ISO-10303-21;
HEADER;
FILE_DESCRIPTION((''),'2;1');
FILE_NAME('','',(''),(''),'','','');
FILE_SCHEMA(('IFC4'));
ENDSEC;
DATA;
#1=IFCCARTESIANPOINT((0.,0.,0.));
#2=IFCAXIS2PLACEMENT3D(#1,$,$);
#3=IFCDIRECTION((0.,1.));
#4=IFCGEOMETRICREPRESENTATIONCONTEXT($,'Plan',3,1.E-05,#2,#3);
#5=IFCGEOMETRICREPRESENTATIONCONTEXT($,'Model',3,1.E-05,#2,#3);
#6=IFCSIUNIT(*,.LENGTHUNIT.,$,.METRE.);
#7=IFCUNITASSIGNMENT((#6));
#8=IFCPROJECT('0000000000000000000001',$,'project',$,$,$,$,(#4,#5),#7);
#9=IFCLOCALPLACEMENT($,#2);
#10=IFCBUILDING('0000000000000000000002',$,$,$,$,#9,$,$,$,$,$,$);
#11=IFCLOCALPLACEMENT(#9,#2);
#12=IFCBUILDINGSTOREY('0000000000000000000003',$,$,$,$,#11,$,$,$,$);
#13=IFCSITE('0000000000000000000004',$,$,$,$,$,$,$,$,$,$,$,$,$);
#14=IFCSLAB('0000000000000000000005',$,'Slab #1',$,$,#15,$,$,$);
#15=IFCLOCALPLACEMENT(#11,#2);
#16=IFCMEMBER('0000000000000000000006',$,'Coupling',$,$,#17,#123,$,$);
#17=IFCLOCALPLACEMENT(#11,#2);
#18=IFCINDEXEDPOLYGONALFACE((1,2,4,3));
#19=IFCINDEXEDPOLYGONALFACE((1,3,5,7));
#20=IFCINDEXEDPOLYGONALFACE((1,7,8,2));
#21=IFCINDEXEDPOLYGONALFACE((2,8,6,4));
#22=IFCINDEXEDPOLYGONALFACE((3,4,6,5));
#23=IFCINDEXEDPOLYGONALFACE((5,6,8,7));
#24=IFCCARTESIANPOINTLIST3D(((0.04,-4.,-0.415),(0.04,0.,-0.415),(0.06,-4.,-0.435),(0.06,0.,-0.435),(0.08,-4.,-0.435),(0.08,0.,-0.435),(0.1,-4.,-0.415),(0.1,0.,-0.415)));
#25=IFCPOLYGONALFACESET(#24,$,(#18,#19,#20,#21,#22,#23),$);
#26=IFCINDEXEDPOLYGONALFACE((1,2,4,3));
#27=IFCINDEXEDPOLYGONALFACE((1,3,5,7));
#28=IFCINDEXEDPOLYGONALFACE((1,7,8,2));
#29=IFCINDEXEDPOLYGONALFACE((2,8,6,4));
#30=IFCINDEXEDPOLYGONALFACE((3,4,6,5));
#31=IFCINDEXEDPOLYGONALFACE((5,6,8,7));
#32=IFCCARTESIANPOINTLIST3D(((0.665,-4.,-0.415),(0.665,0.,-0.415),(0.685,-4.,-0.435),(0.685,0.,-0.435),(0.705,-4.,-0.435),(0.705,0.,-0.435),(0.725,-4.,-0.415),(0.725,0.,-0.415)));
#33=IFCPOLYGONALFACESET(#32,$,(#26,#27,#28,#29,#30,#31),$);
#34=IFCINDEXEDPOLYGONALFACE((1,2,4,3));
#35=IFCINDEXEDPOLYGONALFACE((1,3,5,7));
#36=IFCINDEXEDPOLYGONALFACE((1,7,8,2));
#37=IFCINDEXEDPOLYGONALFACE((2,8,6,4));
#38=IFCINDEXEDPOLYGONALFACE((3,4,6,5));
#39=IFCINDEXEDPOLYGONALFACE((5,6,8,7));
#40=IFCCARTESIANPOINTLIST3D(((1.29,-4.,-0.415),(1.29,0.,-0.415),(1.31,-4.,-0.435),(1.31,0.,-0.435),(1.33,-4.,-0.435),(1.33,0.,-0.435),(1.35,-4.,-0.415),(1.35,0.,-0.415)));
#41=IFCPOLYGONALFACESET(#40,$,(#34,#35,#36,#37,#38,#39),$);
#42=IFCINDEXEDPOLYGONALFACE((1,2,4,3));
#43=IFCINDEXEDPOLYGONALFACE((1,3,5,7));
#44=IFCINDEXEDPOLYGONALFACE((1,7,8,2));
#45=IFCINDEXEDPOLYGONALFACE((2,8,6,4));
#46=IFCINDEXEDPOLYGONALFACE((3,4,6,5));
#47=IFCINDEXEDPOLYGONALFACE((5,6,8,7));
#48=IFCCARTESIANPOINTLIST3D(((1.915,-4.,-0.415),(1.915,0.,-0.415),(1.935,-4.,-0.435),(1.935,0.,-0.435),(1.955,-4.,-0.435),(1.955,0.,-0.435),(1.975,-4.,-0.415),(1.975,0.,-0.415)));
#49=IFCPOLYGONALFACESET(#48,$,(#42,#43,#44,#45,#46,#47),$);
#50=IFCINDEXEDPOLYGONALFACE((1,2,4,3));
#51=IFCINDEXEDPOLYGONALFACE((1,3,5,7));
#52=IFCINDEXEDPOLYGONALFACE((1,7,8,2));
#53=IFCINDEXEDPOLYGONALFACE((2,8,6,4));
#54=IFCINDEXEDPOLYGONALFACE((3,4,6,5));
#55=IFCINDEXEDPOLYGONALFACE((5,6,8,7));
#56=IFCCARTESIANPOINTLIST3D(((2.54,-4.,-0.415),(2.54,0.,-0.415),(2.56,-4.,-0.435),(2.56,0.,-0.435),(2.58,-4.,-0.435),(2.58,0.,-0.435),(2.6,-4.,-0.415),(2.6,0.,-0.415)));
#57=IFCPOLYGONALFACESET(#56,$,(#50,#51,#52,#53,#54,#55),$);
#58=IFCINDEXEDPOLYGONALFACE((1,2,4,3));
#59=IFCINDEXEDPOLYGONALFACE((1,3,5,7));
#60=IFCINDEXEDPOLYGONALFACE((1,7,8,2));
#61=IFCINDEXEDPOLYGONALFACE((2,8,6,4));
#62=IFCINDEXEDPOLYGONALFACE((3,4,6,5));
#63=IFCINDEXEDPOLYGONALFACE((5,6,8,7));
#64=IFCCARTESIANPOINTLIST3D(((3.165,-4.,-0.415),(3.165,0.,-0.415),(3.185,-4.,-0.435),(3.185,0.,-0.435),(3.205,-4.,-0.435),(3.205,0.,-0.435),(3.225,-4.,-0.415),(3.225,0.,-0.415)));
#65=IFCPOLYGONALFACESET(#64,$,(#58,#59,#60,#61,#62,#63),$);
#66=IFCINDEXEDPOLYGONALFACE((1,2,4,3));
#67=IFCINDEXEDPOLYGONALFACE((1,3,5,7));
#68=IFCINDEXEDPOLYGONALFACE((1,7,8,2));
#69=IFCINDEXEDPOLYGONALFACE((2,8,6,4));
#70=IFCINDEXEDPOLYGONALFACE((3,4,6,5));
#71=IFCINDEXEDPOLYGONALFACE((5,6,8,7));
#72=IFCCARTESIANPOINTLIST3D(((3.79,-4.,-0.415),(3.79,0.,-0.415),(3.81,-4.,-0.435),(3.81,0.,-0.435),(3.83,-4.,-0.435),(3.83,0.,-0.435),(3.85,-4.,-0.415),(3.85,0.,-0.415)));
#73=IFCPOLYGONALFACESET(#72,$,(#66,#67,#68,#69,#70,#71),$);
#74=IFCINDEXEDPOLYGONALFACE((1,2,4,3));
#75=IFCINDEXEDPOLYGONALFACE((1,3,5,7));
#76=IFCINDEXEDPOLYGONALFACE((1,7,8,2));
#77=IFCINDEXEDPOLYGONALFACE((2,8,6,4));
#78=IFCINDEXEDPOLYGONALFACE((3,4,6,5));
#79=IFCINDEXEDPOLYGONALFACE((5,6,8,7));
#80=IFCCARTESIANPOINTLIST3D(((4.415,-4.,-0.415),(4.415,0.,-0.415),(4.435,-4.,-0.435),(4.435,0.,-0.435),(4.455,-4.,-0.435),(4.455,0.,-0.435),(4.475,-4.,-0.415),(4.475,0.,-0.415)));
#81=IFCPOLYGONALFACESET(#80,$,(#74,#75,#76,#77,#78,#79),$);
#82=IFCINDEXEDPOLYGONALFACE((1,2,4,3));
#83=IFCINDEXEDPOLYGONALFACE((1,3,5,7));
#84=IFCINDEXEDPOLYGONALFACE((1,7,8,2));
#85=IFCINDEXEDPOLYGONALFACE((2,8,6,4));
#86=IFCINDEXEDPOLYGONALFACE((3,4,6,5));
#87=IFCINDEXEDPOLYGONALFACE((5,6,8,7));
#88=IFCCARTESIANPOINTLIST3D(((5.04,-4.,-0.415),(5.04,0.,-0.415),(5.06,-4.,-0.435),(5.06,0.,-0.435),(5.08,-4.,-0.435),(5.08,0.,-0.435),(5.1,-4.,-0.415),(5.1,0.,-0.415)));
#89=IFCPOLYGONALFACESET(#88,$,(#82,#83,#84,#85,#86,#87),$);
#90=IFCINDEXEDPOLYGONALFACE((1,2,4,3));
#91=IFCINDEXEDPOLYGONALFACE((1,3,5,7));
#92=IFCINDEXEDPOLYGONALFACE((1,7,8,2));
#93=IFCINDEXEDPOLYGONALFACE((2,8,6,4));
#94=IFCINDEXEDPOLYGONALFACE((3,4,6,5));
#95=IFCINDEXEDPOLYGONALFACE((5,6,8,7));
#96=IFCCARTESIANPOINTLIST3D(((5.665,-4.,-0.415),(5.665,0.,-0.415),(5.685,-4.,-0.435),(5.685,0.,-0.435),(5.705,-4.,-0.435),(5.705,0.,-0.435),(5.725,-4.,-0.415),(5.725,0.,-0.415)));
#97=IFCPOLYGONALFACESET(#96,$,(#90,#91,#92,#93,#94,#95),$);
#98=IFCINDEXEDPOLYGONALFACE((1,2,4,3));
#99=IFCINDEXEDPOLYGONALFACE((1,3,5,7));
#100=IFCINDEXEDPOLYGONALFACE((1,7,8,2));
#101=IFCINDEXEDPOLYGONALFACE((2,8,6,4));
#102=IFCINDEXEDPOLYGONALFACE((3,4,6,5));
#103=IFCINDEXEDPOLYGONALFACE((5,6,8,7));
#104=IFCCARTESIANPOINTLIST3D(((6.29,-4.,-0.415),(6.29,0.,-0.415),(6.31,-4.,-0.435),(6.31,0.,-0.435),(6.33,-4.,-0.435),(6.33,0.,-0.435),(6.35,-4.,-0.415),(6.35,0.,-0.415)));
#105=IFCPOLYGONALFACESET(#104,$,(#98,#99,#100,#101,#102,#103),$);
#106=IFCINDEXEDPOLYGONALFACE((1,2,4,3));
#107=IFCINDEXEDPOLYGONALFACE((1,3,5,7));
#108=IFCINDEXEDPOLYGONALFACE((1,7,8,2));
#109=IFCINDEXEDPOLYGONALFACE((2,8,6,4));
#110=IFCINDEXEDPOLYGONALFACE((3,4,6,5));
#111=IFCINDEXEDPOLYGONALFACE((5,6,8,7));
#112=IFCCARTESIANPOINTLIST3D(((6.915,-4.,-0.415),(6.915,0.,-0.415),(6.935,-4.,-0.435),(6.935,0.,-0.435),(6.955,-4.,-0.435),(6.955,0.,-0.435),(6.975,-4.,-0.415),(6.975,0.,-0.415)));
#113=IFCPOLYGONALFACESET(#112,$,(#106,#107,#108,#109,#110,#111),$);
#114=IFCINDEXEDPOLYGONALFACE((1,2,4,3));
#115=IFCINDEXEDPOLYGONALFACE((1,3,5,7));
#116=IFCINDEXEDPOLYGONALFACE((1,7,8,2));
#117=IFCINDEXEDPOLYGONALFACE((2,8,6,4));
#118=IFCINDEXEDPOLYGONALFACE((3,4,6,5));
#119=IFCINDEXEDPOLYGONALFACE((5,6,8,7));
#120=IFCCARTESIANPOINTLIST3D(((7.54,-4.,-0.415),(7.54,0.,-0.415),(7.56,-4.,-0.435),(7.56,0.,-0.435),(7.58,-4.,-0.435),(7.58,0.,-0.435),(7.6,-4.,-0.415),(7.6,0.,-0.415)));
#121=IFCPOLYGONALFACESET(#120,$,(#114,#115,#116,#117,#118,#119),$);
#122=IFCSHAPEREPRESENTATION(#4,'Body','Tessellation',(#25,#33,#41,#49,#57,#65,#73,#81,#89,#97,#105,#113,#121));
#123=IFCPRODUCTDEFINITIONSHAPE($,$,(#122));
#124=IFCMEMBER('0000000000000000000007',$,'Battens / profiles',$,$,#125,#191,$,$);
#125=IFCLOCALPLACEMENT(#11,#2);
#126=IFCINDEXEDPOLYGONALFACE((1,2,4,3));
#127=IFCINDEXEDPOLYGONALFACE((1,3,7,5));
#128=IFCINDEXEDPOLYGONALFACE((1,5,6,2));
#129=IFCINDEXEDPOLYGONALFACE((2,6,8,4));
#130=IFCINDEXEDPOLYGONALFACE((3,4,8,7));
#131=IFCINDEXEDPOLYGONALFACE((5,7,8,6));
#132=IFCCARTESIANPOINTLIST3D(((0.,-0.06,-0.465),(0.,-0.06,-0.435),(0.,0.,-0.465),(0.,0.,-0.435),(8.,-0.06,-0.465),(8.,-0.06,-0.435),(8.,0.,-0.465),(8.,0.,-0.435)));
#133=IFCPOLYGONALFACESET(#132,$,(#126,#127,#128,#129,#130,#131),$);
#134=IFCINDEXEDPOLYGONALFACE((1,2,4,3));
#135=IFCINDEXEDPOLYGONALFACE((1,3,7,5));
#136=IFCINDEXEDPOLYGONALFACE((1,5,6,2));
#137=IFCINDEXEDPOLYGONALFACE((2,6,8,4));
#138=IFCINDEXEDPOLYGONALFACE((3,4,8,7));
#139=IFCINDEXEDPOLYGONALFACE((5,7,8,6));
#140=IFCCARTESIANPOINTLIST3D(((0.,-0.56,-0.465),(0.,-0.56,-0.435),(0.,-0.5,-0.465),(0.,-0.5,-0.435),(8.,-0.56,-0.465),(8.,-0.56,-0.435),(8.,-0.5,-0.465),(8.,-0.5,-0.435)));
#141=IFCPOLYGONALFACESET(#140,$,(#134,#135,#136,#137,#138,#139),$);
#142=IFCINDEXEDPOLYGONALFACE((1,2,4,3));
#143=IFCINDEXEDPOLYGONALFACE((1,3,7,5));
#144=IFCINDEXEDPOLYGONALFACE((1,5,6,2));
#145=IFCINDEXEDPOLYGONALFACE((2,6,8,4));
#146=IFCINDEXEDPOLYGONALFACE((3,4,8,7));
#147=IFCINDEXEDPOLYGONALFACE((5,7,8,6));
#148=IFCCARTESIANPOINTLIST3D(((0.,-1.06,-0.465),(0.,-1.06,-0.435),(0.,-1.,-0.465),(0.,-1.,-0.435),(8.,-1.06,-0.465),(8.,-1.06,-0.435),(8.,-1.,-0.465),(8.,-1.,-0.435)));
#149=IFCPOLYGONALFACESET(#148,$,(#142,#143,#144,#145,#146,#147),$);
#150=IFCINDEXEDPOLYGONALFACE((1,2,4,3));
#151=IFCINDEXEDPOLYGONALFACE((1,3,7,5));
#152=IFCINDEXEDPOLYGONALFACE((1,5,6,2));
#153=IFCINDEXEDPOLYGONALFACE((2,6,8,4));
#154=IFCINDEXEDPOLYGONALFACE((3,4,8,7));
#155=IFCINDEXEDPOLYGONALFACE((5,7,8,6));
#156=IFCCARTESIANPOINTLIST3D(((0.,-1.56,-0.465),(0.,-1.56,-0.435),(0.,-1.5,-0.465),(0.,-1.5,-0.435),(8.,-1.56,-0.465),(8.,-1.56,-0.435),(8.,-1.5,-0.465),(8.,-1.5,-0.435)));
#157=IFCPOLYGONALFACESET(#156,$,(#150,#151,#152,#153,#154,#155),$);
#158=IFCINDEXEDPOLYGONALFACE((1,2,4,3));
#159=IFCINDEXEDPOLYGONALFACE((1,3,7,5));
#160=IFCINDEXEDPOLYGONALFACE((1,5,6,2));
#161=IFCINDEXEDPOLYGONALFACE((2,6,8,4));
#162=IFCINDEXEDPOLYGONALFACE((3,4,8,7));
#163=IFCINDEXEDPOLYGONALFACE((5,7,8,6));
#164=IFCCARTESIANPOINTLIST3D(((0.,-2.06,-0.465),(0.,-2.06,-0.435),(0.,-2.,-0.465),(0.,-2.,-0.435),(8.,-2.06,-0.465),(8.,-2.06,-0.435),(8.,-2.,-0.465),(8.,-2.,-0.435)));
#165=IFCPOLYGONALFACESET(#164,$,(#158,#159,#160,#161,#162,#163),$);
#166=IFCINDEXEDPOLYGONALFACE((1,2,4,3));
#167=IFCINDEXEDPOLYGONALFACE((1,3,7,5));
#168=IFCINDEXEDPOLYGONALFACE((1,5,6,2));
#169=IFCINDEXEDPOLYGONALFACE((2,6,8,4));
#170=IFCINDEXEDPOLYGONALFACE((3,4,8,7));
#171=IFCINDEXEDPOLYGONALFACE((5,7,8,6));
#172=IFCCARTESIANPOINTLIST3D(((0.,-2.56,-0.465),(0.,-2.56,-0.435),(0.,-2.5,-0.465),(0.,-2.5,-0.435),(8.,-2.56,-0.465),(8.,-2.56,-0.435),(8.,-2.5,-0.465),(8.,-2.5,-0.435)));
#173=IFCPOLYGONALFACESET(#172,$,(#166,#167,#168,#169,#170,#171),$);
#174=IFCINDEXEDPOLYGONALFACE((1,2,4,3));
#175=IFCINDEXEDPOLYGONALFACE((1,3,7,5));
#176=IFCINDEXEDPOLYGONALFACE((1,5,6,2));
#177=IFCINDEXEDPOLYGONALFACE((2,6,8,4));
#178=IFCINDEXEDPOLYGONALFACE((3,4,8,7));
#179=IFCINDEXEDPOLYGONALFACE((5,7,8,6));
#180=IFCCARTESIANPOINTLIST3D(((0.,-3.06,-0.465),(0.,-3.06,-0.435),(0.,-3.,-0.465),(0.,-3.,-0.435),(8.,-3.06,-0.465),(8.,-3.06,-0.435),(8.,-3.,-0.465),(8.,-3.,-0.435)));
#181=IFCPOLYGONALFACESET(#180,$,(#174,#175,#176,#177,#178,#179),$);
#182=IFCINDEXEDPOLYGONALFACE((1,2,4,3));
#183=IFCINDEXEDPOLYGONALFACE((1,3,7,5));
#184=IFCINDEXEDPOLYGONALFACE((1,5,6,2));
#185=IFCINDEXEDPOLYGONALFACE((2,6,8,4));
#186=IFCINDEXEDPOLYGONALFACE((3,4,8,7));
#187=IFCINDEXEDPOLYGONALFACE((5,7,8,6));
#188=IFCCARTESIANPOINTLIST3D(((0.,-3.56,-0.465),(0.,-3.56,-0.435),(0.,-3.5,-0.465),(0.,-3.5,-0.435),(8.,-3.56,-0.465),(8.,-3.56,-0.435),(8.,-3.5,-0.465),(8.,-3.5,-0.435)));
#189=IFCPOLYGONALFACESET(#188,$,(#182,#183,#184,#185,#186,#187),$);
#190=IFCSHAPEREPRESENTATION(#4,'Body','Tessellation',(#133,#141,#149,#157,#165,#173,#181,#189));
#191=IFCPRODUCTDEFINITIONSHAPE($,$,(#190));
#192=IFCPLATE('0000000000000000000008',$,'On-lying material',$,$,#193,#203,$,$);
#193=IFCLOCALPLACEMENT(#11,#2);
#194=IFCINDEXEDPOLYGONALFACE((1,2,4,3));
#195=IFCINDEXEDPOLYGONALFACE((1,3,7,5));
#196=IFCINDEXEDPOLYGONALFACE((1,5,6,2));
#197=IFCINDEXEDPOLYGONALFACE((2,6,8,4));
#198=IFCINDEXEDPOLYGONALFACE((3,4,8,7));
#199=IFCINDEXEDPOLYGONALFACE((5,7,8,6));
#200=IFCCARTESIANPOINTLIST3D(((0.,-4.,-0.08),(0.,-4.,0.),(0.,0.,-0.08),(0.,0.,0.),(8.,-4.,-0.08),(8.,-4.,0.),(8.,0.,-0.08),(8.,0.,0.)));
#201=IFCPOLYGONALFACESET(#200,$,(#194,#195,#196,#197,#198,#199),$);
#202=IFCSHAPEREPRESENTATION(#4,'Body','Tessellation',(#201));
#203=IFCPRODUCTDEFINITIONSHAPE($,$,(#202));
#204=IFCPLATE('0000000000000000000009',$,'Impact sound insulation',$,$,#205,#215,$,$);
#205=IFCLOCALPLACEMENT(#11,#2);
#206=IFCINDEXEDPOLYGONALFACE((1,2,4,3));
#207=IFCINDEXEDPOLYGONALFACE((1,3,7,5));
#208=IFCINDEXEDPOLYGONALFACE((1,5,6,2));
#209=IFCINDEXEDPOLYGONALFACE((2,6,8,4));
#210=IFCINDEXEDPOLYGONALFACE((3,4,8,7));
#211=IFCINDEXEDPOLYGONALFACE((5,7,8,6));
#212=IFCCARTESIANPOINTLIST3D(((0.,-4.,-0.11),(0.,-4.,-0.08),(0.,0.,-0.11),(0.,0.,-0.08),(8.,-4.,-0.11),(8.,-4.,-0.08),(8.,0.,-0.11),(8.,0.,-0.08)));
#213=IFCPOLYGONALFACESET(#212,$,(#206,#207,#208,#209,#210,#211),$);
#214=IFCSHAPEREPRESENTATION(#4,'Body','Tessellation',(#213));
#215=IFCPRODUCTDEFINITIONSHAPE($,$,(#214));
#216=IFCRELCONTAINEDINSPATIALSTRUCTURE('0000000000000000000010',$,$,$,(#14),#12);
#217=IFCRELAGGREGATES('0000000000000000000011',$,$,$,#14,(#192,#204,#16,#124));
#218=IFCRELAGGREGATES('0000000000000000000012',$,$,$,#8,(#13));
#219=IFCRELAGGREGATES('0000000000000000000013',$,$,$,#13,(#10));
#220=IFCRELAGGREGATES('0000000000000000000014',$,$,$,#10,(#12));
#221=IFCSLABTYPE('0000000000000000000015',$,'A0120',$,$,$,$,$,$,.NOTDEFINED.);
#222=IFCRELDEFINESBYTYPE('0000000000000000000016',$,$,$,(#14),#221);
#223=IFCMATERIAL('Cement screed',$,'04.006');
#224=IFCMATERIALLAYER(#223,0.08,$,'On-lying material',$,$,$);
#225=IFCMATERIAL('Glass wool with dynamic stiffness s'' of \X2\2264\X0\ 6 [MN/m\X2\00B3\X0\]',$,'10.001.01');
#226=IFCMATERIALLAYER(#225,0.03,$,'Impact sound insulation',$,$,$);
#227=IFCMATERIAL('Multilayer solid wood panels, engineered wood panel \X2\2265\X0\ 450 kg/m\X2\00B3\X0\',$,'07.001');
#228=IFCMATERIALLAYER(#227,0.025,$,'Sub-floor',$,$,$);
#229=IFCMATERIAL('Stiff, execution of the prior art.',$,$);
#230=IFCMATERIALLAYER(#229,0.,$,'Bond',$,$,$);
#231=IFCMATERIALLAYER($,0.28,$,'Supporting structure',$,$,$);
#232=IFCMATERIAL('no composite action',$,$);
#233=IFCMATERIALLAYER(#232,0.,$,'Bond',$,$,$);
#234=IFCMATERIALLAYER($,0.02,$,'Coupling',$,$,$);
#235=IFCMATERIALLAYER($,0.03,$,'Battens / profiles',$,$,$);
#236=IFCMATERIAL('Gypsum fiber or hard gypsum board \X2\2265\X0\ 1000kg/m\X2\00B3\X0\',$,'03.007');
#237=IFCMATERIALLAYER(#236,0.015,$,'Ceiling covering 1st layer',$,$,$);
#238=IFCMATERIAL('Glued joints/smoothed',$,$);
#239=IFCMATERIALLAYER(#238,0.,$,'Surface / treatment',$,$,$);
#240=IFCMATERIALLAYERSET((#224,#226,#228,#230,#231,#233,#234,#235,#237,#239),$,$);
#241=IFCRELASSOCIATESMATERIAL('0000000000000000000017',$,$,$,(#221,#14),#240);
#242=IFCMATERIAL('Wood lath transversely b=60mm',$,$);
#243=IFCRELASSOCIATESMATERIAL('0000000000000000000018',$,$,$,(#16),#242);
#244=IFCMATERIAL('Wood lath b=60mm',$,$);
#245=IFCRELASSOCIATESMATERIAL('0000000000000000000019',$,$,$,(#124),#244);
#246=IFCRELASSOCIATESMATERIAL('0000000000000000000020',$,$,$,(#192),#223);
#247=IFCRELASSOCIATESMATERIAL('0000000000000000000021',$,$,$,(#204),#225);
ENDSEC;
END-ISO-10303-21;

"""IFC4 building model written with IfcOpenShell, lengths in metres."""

from ifc_helpers import new_model, si_unit, direction, frame, frame_2d, origin, origin_with_axes, place, context, project, spatial, polyline, rectangle, outline, extrude, material, layer, layer_set, type_object, element, aggregate, save


model = new_model("IFC4")

# Units and contexts
plan_context = context("Plan", 3, precision=1e-05, world=origin(), true_north=direction((0.0, 1.0)))
model_context = context("Model", 3, precision=1e-05, world=origin(), true_north=direction((0.0, 1.0)))
ifc_project = project(units=[si_unit("LENGTHUNIT", "METRE")], contexts=[plan_context, model_context])

# Site, building, storey
site = spatial("IfcSite", under=ifc_project)
building_placement = place(None, origin())
building = spatial("IfcBuilding", under=site, at=building_placement)
storey_placement = place(building_placement, origin())
storey = spatial("IfcBuildingStorey", under=building, at=storey_placement)

# Slab, members, plates
ifc_material_1 = material(Name="Cement screed", Category="04.006")
ifc_layer_1 = layer(ifc_material_1, 0.08, Name="On-lying material")
ifc_material_2 = material(Name="Glass wool with dynamic stiffness s' of ≤ 6 [MN/m³]", Category="10.001.01")
ifc_layer_2 = layer(ifc_material_2, 0.03, Name="Impact sound insulation")
ifc_material_3 = material(Name="Multilayer solid wood panels, engineered wood panel ≥ 450 kg/m³", Category="07.001")
ifc_layer_3 = layer(ifc_material_3, 0.025, Name="Sub-floor")
ifc_material_4 = material(Name="Stiff, execution of the prior art.")
ifc_layer_4 = layer(ifc_material_4, 0.0, Name="Bond")
ifc_layer_5 = layer(None, 0.28, Name="Supporting structure")
ifc_material_5 = material(Name="no composite action")
ifc_layer_6 = layer(ifc_material_5, 0.0, Name="Bond")
ifc_layer_7 = layer(None, 0.02, Name="Coupling")
ifc_layer_8 = layer(None, 0.03, Name="Battens / profiles")
ifc_material_6 = material(Name="Gypsum fiber or hard gypsum board ≥ 1000kg/m³", Category="03.007")
ifc_layer_9 = layer(ifc_material_6, 0.015, Name="Ceiling covering 1st layer")
ifc_material_7 = material(Name="Glued joints/smoothed")
ifc_layer_10 = layer(ifc_material_7, 0.0, Name="Surface / treatment")
ifc_layer_set = layer_set([ifc_layer_1, ifc_layer_2, ifc_layer_3, ifc_layer_4, ifc_layer_5, ifc_layer_6, ifc_layer_7, ifc_layer_8, ifc_layer_9, ifc_layer_10])
slab_type = type_object("IfcSlabType", Name="A0120", PredefinedType="NOTDEFINED", material=ifc_layer_set)
slab_placement = place(None, frame((0.0, 0.0, 0.0), z_axis=(0.0, 0.0, -1.0), x_axis=(1.0, 0.0, 0.0)))
slab = element("IfcSlab", 1, at=slab_placement, inside=storey, type_object=slab_type, material=ifc_layer_set, Name="Slab #1")
ifc_material_8 = material(Name="Wood lath transversely b=60mm")
member_1_placement = place(slab_placement, origin())
member_1 = element("IfcMember", 2, at=member_1_placement, material=ifc_material_8, Name="Coupling", context=plan_context, shape_type="SweptSolid", body=[
    extrude(outline(polyline([(0.0, 0.0), (0.06, 0.0), (0.04, 0.02), (0.02, 0.02), (0.0, 0.0)])), frame((0.04, 4.0, 0.415), z_axis=(0.0, -1.0, 0.0), x_axis=(1.0, 0.0, 0.0)), (0.0, 0.0, 1.0), 4.0),
    extrude(outline(polyline([(0.0, 0.0), (0.06, 0.0), (0.04, 0.02), (0.02, 0.02), (0.0, 0.0)])), frame((0.665, 4.0, 0.415), z_axis=(0.0, -1.0, 0.0), x_axis=(1.0, 0.0, 0.0)), (0.0, 0.0, 1.0), 4.0),
    extrude(outline(polyline([(0.0, 0.0), (0.06, 0.0), (0.04, 0.02), (0.02, 0.02), (0.0, 0.0)])), frame((1.29, 4.0, 0.415), z_axis=(0.0, -1.0, 0.0), x_axis=(1.0, 0.0, 0.0)), (0.0, 0.0, 1.0), 4.0),
    extrude(outline(polyline([(0.0, 0.0), (0.06, 0.0), (0.04, 0.02), (0.02, 0.02), (0.0, 0.0)])), frame((1.915, 4.0, 0.415), z_axis=(0.0, -1.0, 0.0), x_axis=(1.0, 0.0, 0.0)), (0.0, 0.0, 1.0), 4.0),
    extrude(outline(polyline([(0.0, 0.0), (0.06, 0.0), (0.04, 0.02), (0.02, 0.02), (0.0, 0.0)])), frame((2.54, 4.0, 0.415), z_axis=(0.0, -1.0, 0.0), x_axis=(1.0, 0.0, 0.0)), (0.0, 0.0, 1.0), 4.0),
    extrude(outline(polyline([(0.0, 0.0), (0.06, 0.0), (0.04, 0.02), (0.02, 0.02), (0.0, 0.0)])), frame((3.165, 4.0, 0.415), z_axis=(0.0, -1.0, 0.0), x_axis=(1.0, 0.0, 0.0)), (0.0, 0.0, 1.0), 4.0),
    extrude(outline(polyline([(0.0, 0.0), (0.06, 0.0), (0.04, 0.02), (0.02, 0.02), (0.0, 0.0)])), frame((3.79, 4.0, 0.415), z_axis=(0.0, -1.0, 0.0), x_axis=(1.0, 0.0, 0.0)), (0.0, 0.0, 1.0), 4.0),
    extrude(outline(polyline([(0.0, 0.0), (0.06, 0.0), (0.04, 0.02), (0.02, 0.02), (0.0, 0.0)])), frame((4.415, 4.0, 0.415), z_axis=(0.0, -1.0, 0.0), x_axis=(1.0, 0.0, 0.0)), (0.0, 0.0, 1.0), 4.0),
    extrude(outline(polyline([(0.0, 0.0), (0.06, 0.0), (0.04, 0.02), (0.02, 0.02), (0.0, 0.0)])), frame((5.04, 4.0, 0.415), z_axis=(0.0, -1.0, 0.0), x_axis=(1.0, 0.0, 0.0)), (0.0, 0.0, 1.0), 4.0),
    extrude(outline(polyline([(0.0, 0.0), (0.06, 0.0), (0.04, 0.02), (0.02, 0.02), (0.0, 0.0)])), frame((5.665, 4.0, 0.415), z_axis=(0.0, -1.0, 0.0), x_axis=(1.0, 0.0, 0.0)), (0.0, 0.0, 1.0), 4.0),
    extrude(outline(polyline([(0.0, 0.0), (0.06, 0.0), (0.04, 0.02), (0.02, 0.02), (0.0, 0.0)])), frame((6.29, 4.0, 0.415), z_axis=(0.0, -1.0, 0.0), x_axis=(1.0, 0.0, 0.0)), (0.0, 0.0, 1.0), 4.0),
    extrude(outline(polyline([(0.0, 0.0), (0.06, 0.0), (0.04, 0.02), (0.02, 0.02), (0.0, 0.0)])), frame((6.915, 4.0, 0.415), z_axis=(0.0, -1.0, 0.0), x_axis=(1.0, 0.0, 0.0)), (0.0, 0.0, 1.0), 4.0),
    extrude(outline(polyline([(0.0, 0.0), (0.06, 0.0), (0.04, 0.02), (0.02, 0.02), (0.0, 0.0)])), frame((7.54, 4.0, 0.415), z_axis=(0.0, -1.0, 0.0), x_axis=(1.0, 0.0, 0.0)), (0.0, 0.0, 1.0), 4.0),
])
ifc_material_9 = material(Name="Wood lath b=60mm")
member_2_placement = place(slab_placement, origin())
member_2 = element("IfcMember", 3, at=member_2_placement, material=ifc_material_9, Name="Battens / profiles", context=plan_context, shape_type="SweptSolid", body=[
    extrude(rectangle(XDim=0.06, YDim=0.03, at=frame_2d((0.03, 0.015), x_axis=(1.0, 0.0))), frame((0.0, 0.0, 0.435), z_axis=(1.0, 0.0, 0.0), x_axis=(0.0, 1.0, 0.0)), (0.0, 0.0, 1.0), 8.0),
    extrude(rectangle(XDim=0.06, YDim=0.03, at=frame_2d((0.03, 0.015), x_axis=(1.0, 0.0))), frame((0.0, 0.5, 0.435), z_axis=(1.0, 0.0, 0.0), x_axis=(0.0, 1.0, 0.0)), (0.0, 0.0, 1.0), 8.0),
    extrude(rectangle(XDim=0.06, YDim=0.03, at=frame_2d((0.03, 0.015), x_axis=(1.0, 0.0))), frame((0.0, 1.0, 0.435), z_axis=(1.0, 0.0, 0.0), x_axis=(0.0, 1.0, 0.0)), (0.0, 0.0, 1.0), 8.0),
    extrude(rectangle(XDim=0.06, YDim=0.03, at=frame_2d((0.03, 0.015), x_axis=(1.0, 0.0))), frame((0.0, 1.5, 0.435), z_axis=(1.0, 0.0, 0.0), x_axis=(0.0, 1.0, 0.0)), (0.0, 0.0, 1.0), 8.0),
    extrude(rectangle(XDim=0.06, YDim=0.03, at=frame_2d((0.03, 0.015), x_axis=(1.0, 0.0))), frame((0.0, 2.0, 0.435), z_axis=(1.0, 0.0, 0.0), x_axis=(0.0, 1.0, 0.0)), (0.0, 0.0, 1.0), 8.0),
    extrude(rectangle(XDim=0.06, YDim=0.03, at=frame_2d((0.03, 0.015), x_axis=(1.0, 0.0))), frame((0.0, 2.5, 0.435), z_axis=(1.0, 0.0, 0.0), x_axis=(0.0, 1.0, 0.0)), (0.0, 0.0, 1.0), 8.0),
    extrude(rectangle(XDim=0.06, YDim=0.03, at=frame_2d((0.03, 0.015), x_axis=(1.0, 0.0))), frame((0.0, 3.0, 0.435), z_axis=(1.0, 0.0, 0.0), x_axis=(0.0, 1.0, 0.0)), (0.0, 0.0, 1.0), 8.0),
    extrude(rectangle(XDim=0.06, YDim=0.03, at=frame_2d((0.03, 0.015), x_axis=(1.0, 0.0))), frame((0.0, 3.5, 0.435), z_axis=(1.0, 0.0, 0.0), x_axis=(0.0, 1.0, 0.0)), (0.0, 0.0, 1.0), 8.0),
])
plate_1_placement = place(slab_placement, origin())
plate_1 = element("IfcPlate", 4, at=plate_1_placement, material=ifc_material_1, Name="On-lying material", context=plan_context, shape_type="SweptSolid", body=[
    extrude(rectangle(XDim=8.0, YDim=4.0, at=frame_2d((4.0, 2.0), x_axis=(1.0, 0.0))), origin_with_axes(), (0.0, 0.0, 1.0), 0.08),
])
plate_2_placement = place(slab_placement, origin())
plate_2 = element("IfcPlate", 5, at=plate_2_placement, material=ifc_material_2, Name="Impact sound insulation", context=plan_context, shape_type="SweptSolid", body=[
    extrude(rectangle(XDim=8.0, YDim=4.0, at=frame_2d((4.0, 2.0), x_axis=(1.0, 0.0))), frame((0.0, 0.0, 0.08), z_axis=(0.0, 0.0, 1.0), x_axis=(1.0, 0.0, 0.0)), (0.0, 0.0, 1.0), 0.03),
])
aggregate(slab, [plate_1, plate_2, member_1, member_2])

save(model, "model.ifc")
